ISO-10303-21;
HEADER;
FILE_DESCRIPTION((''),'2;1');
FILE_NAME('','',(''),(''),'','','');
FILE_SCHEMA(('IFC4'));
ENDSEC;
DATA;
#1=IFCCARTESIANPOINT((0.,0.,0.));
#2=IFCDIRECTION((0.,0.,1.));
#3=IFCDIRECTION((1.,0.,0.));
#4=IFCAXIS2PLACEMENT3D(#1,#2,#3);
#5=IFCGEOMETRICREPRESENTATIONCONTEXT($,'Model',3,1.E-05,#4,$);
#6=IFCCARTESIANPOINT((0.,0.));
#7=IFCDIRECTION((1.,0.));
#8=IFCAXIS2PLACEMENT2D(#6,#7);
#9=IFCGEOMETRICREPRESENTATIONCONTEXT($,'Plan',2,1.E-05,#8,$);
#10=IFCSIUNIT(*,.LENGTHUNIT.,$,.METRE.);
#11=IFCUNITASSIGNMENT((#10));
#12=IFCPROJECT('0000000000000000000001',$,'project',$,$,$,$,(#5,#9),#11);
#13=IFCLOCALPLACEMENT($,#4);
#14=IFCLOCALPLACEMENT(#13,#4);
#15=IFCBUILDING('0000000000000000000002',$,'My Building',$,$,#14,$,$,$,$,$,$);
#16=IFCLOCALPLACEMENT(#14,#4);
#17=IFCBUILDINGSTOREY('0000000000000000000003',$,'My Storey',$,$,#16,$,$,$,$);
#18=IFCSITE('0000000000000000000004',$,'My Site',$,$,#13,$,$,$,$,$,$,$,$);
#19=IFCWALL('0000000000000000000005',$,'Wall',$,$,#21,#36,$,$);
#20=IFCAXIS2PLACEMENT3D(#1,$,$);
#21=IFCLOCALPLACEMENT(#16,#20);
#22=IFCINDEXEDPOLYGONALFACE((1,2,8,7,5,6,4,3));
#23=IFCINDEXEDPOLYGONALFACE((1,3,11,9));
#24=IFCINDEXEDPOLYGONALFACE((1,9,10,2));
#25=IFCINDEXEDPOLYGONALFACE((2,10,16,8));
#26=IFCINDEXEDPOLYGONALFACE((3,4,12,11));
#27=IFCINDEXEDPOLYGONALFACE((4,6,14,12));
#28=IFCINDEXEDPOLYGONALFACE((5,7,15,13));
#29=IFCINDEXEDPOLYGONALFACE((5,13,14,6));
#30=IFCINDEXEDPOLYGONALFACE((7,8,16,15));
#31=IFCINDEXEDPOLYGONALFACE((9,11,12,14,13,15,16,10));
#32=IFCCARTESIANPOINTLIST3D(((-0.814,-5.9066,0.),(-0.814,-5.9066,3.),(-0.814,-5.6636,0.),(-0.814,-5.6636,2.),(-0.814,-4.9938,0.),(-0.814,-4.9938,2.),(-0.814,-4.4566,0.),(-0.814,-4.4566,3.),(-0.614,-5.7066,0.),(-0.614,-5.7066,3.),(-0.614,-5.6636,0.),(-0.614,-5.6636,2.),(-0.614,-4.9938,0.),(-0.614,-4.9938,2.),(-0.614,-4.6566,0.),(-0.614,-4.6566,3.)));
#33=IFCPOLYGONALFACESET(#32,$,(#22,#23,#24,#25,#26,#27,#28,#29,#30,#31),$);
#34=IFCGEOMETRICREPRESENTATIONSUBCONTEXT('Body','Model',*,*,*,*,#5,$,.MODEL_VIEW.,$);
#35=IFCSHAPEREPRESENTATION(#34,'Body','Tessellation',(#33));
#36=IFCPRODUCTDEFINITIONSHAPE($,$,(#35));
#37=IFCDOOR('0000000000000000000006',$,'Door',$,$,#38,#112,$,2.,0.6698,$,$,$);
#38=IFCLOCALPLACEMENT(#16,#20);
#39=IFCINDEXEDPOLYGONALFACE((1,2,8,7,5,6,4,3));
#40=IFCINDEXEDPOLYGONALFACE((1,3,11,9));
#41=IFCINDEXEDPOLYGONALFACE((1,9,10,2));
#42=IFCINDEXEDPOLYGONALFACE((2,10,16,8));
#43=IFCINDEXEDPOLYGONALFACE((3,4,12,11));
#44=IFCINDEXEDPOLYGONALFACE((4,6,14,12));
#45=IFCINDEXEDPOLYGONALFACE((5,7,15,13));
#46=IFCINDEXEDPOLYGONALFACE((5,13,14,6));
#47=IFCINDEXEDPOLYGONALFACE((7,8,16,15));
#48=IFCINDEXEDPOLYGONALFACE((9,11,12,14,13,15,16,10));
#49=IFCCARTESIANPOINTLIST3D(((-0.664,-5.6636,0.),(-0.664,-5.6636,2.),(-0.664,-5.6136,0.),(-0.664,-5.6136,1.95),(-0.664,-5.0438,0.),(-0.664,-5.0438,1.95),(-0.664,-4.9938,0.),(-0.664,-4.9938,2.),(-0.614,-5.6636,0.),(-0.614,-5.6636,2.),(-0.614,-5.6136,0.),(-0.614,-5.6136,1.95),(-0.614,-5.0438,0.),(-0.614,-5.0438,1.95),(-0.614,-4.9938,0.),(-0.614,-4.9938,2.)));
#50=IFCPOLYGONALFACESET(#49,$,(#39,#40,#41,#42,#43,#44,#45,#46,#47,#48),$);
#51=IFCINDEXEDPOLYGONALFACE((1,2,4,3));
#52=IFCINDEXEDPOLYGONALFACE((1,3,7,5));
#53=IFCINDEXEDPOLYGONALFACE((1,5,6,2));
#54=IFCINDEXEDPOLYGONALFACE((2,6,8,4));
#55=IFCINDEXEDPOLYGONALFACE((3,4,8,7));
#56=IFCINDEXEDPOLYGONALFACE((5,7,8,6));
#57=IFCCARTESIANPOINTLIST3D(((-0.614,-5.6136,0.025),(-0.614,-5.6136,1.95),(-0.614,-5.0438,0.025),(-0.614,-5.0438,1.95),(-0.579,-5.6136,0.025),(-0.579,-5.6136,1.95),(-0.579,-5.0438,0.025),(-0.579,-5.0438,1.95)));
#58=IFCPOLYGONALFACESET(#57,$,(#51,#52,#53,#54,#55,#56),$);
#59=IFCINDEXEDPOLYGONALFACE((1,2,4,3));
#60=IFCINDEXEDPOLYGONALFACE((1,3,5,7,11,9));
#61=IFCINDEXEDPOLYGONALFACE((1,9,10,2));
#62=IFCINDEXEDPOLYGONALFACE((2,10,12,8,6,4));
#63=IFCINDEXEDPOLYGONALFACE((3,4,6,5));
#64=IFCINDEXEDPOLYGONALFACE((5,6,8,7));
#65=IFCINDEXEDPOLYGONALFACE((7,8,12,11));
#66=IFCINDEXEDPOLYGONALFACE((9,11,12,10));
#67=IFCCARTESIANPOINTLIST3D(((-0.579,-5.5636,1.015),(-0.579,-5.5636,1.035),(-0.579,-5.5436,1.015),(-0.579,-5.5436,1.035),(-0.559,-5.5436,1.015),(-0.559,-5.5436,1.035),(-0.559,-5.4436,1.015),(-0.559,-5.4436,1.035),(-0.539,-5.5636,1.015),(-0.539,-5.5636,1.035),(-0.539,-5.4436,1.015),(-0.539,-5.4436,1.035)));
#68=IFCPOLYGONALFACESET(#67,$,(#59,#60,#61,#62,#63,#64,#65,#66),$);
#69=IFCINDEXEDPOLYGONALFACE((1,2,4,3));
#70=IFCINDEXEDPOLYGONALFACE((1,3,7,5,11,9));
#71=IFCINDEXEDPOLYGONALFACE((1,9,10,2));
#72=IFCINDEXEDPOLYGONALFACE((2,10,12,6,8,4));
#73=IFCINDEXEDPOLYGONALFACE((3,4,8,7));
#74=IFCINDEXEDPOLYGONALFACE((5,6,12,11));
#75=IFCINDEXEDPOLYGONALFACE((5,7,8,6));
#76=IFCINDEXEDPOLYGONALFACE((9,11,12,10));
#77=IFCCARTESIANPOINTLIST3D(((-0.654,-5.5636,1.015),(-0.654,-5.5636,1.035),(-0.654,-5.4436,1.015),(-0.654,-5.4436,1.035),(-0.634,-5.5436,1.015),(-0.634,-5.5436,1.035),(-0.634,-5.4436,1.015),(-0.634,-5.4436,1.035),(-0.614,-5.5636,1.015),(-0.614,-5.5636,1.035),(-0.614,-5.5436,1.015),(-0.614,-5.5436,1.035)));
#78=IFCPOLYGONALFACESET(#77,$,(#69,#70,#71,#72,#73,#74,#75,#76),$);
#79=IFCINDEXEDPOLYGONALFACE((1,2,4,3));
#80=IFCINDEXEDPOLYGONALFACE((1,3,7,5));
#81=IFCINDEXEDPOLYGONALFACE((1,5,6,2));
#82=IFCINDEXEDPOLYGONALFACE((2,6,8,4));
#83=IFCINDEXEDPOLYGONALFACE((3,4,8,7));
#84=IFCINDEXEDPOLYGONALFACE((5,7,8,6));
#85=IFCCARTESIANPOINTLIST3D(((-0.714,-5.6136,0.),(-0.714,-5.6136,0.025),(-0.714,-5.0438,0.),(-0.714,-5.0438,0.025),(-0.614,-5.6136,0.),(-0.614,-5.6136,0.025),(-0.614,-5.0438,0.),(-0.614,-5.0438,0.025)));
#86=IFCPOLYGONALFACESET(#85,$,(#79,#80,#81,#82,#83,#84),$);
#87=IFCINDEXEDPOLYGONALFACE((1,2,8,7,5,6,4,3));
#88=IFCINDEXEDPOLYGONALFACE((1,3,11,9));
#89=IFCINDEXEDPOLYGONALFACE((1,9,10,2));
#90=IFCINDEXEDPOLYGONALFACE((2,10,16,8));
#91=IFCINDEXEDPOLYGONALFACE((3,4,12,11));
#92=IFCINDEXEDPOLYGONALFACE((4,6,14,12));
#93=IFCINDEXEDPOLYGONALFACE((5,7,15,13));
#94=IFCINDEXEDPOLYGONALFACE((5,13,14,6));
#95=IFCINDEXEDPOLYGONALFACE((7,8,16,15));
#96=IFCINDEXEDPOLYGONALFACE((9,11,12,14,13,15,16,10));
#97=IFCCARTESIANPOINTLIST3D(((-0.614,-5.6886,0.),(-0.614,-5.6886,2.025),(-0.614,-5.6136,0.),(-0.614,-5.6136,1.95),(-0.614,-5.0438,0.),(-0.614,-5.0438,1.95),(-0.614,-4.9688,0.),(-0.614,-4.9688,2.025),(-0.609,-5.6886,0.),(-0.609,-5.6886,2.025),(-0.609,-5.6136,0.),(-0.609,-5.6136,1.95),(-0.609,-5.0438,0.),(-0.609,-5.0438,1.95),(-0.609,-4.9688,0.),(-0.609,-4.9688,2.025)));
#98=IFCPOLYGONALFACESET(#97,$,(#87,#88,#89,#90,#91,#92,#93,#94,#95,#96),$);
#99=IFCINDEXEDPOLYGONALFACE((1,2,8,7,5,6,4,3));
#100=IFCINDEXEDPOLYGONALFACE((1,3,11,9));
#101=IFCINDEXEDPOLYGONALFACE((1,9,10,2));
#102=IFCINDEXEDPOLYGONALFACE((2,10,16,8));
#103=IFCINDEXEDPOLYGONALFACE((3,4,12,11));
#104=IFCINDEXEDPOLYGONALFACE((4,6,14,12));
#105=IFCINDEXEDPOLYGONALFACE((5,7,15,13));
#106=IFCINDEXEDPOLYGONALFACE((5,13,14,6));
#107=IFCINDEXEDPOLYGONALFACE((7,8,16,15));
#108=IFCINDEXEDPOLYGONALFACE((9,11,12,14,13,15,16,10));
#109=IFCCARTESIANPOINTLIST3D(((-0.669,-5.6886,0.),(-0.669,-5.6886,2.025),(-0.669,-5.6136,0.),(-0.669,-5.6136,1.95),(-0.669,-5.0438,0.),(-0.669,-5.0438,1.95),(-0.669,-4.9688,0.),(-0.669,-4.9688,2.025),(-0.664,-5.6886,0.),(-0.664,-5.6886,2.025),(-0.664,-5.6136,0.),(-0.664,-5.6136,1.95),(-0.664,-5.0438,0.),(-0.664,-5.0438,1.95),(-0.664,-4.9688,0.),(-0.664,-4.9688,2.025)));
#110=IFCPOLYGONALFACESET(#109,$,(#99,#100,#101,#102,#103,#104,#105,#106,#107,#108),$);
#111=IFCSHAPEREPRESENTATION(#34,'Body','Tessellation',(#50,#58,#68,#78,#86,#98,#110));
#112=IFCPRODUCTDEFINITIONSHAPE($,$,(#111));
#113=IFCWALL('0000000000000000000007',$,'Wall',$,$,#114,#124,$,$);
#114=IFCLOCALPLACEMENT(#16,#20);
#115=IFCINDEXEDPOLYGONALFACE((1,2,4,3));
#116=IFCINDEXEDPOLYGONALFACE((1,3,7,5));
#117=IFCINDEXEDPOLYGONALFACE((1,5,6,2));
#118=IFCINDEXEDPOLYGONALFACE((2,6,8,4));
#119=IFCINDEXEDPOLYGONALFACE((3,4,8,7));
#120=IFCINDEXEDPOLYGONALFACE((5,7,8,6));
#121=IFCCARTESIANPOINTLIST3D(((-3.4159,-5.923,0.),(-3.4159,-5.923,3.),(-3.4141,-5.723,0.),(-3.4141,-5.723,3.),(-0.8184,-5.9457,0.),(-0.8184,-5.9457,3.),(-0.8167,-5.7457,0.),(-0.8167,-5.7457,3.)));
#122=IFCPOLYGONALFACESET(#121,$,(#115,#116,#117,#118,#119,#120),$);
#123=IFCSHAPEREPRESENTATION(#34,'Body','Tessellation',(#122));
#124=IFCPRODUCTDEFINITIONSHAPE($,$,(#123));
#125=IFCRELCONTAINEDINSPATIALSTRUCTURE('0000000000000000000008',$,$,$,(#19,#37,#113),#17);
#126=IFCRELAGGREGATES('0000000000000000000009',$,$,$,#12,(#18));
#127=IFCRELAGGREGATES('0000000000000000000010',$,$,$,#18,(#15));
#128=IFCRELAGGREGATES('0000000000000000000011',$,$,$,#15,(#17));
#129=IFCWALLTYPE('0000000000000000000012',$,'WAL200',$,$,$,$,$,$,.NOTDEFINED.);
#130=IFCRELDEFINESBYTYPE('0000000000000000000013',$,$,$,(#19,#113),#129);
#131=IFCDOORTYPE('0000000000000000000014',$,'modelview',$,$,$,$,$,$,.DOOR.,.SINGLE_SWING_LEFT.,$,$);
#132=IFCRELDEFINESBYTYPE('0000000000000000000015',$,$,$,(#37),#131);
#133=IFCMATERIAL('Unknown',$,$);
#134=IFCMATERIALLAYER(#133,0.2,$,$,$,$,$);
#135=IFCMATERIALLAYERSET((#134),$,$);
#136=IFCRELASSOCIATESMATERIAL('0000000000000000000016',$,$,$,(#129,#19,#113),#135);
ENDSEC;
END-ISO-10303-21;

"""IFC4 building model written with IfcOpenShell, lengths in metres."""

from ifc_helpers import new_model, entity, si_unit, frame, origin_with_axes, origin_2d_with_axis, place, context, subcontext, project, spatial, line, indexed_curve, outline, extrude, shape, source, transform, mapped, material, layer, layer_set, layer_usage, type_object, type_shapes, element, fill, save


model = new_model("IFC4")

# Units and contexts
model_context = context("Model", 3, precision=1e-05, world=origin_with_axes())
plan_context = context("Plan", 2, precision=1e-05, world=origin_2d_with_axis())
body_context_1 = subcontext(model_context, "Body", "Model", "MODEL_VIEW")
body_context_2 = subcontext(plan_context, "Body", "Plan", "PLAN_VIEW")
ifc_project = project(units=[si_unit("LENGTHUNIT", "METRE")], contexts=[model_context, plan_context])

# Site, building, storey
site_placement = place(None, origin_with_axes())
site = spatial("IfcSite", under=ifc_project, at=site_placement, Name="My Site")
building_placement = place(site_placement, origin_with_axes())
building = spatial("IfcBuilding", under=site, at=building_placement, Name="My Building")
storey_placement = place(building_placement, origin_with_axes())
storey = spatial("IfcBuildingStorey", under=building, at=storey_placement, Name="My Storey")

# Shared definitions
ifc_material = material(Name="Unknown")

# Shared definitions
shared_shape_1 = source(origin_with_axes(), body_context_1, "Body", "SweptSolid", [
    extrude(outline(indexed_curve([(0.0, 0.0), (0.6698, 0.0), (0.6698, 2.0), (0.0, 2.0)], segments=[line(1, 2, 3, 4, 1)])), frame((0.0, -0.6, 0.0), z_axis=(0.0, -1.0, 0.0), x_axis=(1.0, 0.0, 0.0)), (0.0, 0.0, -1.0), 1.2),
])
door_type_1 = type_object("IfcDoorType", Name="modelview", OperationType="SINGLE_SWING_LEFT", PredefinedType="DOOR")
shared_shape_2 = source(origin_with_axes(), body_context_1, "Body", "SweptSolid", [
    extrude(outline(indexed_curve([(0.0, 0.0), (0.0, 2.0), (0.6698, 2.0), (0.6698, 0.0), (0.6198, 0.0), (0.6198, 1.95), (0.05, 1.95), (0.05, 0.0)], segments=[line(1, 2, 3, 4, 5, 6, 7, 8, 1)])), frame((0.0, 0.0, 0.0), z_axis=(0.0, -1.0, 0.0), x_axis=(1.0, 0.0, 0.0)), (0.0, 0.0, -1.0), 0.05),
    extrude(outline(indexed_curve([(0.0, 0.0), (0.5698, 0.0), (0.5698, 0.035), (0.0, 0.035)], segments=[line(1, 2, 3, 4, 1)])), frame((0.05, -0.035, 0.025), z_axis=(0.0, 0.0, 1.0), x_axis=(1.0, 0.0, 0.0)), (0.0, 0.0, 1.0), 1.925),
    extrude(outline(indexed_curve([(0.0, 0.0), (0.0, -0.04), (0.12, -0.04), (0.12, -0.02), (0.02, -0.02), (0.02, 0.0)], segments=[line(1, 2, 3, 4, 5, 6, 1)])), frame((0.1, -0.035, 1.015), z_axis=(0.0, 0.0, 1.0), x_axis=(1.0, 0.0, 0.0)), (0.0, 0.0, 1.0), 0.02),
    extrude(outline(indexed_curve([(0.0, 0.0), (0.0, 0.04), (0.12, 0.04), (0.12, 0.02), (0.02, 0.02), (0.02, 0.0)], segments=[line(1, 2, 3, 4, 5, 6, 1)])), frame((0.1, 0.0, 1.015), z_axis=(0.0, 0.0, 1.0), x_axis=(1.0, 0.0, 0.0)), (0.0, 0.0, 1.0), 0.02),
    extrude(outline(indexed_curve([(0.0, 0.0), (0.5698, 0.0), (0.5698, 0.1), (0.0, 0.1)], segments=[line(1, 2, 3, 4, 1)])), frame((0.05, 0.0, 0.0), z_axis=(0.0, 0.0, 1.0), x_axis=(1.0, 0.0, 0.0)), (0.0, 0.0, 1.0), 0.025),
    extrude(outline(indexed_curve([(0.0, 0.0), (0.0, 2.025), (0.7198, 2.025), (0.7198, 0.0), (0.6448, 0.0), (0.6448, 1.95), (0.075, 1.95), (0.075, 0.0)], segments=[line(1, 2, 3, 4, 5, 6, 7, 8, 1)])), frame((-0.025, -0.005, 0.0), z_axis=(0.0, -1.0, 0.0), x_axis=(1.0, 0.0, 0.0)), (0.0, 0.0, -1.0), 0.005),
    extrude(outline(indexed_curve([(0.0, 0.0), (0.0, 2.025), (0.7198, 2.025), (0.7198, 0.0), (0.6448, 0.0), (0.6448, 1.95), (0.075, 1.95), (0.075, 0.0)], segments=[line(1, 2, 3, 4, 5, 6, 7, 8, 1)])), frame((-0.025, 0.05, 0.0), z_axis=(0.0, -1.0, 0.0), x_axis=(1.0, 0.0, 0.0)), (0.0, 0.0, -1.0), 0.005),
])
shared_shape_3 = source(origin_with_axes(), body_context_2, "Body", "Curve2D", [
    entity("IfcIndexedPolyCurve", entity("IfcCartesianPointList2D", [[0.0, 0.0], [0.05, 0.0], [0.05, 0.05], [0.0, 0.05]]), [entity("IfcLineIndex", [1, 2, 3, 4, 1])]),
    entity("IfcIndexedPolyCurve", entity("IfcCartesianPointList2D", [[0.6698, 0.0], [0.6198, 0.0], [0.6198, 0.05], [0.6698, 0.05]]), [entity("IfcLineIndex", [1, 2, 3, 4, 1])]),
    entity("IfcIndexedPolyCurve", entity("IfcCartesianPointList2D", [[0.9047, -0.035], [0.3349, -0.035], [0.3349, 0.0], [0.9047, 0.0]]), [entity("IfcLineIndex", [1, 2, 3, 4, 1])]),
])
type_shapes(door_type_1, [shared_shape_2, shared_shape_3])

# Shared definitions
ifc_layer_1 = layer(ifc_material, 0.2)
ifc_layer_set_1 = layer_set([ifc_layer_1])
wall_type_1 = type_object("IfcWallType", Name="WAL200", PredefinedType="NOTDEFINED", material=ifc_layer_set_1)

# Wall, opening, door
ifc_layer_usage_1 = layer_usage(ifc_layer_set_1, "AXIS2", "POSITIVE", 0.0)
wall_1_placement = place(storey_placement, frame((-0.814, -4.4566, 0.0), z_axis=(0.0, 0.0, 1.0), x_axis=(0.0, -1.0, 0.0)))
wall_1 = element("IfcWall", 1, at=wall_1_placement, inside=storey, type_object=wall_type_1, material=ifc_layer_usage_1, Name="Wall", context=body_context_1, shape_type="SweptSolid", body=[
    extrude(outline(indexed_curve([(0.0, 0.0), (0.2, 0.2), (1.25, 0.2), (1.45, 0.0)], segments=[line(1, 2, 3, 4, 1)])), origin_with_axes(), (0.0, 0.0, 1.0), 3.0),
])
opening_1_placement = place(wall_1_placement, frame((1.2071, 0.2, 0.0), z_axis=(0.0, 0.0, 1.0), x_axis=(-1.0, 0.0, 0.0)))
opening_1 = element("IfcOpeningElement", 2, at=opening_1_placement, cuts=wall_1, PredefinedType="OPENING", context=body_context_1, shape_type="MappedRepresentation", body=[
    mapped(shared_shape_1, transform((0.0, 0.0, 0.0), x_axis=(1.0, 0.0, 0.0), y_axis=(0.0, 1.0, 0.0), z_axis=(0.0, 0.0, 1.0), scale=1.0)),
])
door_1_placement = place(opening_1_placement, frame((0.0, 0.0, 0.0), z_axis=(0.0, 0.0, 1.0), x_axis=(1.0, 0.0, 0.0)))
door_1 = element("IfcDoor", 3, at=door_1_placement, inside=storey, type_object=door_type_1, Name="Door", OverallHeight=2.0, OverallWidth=0.6698, shapes=[
    shape(body_context_1, "Body", "MappedRepresentation", [mapped(shared_shape_2, transform((0.0, 0.0, 0.0), x_axis=(1.0, 0.0, 0.0), y_axis=(0.0, 1.0, 0.0), z_axis=(0.0, 0.0, 1.0), scale=1.0))]),
    shape(body_context_2, "Body", "MappedRepresentation", [mapped(shared_shape_3, transform((0.0, 0.0, 0.0), x_axis=(1.0, 0.0, 0.0), y_axis=(0.0, 1.0, 0.0), z_axis=(0.0, 0.0, 1.0), scale=1.0))]),
])
fill(opening_1, door_1)

# Wall
ifc_layer_usage_2 = layer_usage(ifc_layer_set_1, "AXIS2", "POSITIVE", 0.0)
wall_2_placement = place(storey_placement, frame((-3.4159, -5.923, 0.0), z_axis=(0.0, 0.0, 1.0), x_axis=(0.999962, -0.008764, 0.0)))
element("IfcWall", 4, at=wall_2_placement, inside=storey, type_object=wall_type_1, material=ifc_layer_usage_2, Name="Wall", context=body_context_1, shape_type="SweptSolid", body=[
    extrude(outline(indexed_curve([(0.0, 0.0), (0.0, 0.2), (2.5975, 0.2), (2.5975, 0.0)], segments=[line(1, 2, 3, 4, 1)])), origin_with_axes(), (0.0, 0.0, 1.0), 3.0),
])

save(model, "model.ifc")
